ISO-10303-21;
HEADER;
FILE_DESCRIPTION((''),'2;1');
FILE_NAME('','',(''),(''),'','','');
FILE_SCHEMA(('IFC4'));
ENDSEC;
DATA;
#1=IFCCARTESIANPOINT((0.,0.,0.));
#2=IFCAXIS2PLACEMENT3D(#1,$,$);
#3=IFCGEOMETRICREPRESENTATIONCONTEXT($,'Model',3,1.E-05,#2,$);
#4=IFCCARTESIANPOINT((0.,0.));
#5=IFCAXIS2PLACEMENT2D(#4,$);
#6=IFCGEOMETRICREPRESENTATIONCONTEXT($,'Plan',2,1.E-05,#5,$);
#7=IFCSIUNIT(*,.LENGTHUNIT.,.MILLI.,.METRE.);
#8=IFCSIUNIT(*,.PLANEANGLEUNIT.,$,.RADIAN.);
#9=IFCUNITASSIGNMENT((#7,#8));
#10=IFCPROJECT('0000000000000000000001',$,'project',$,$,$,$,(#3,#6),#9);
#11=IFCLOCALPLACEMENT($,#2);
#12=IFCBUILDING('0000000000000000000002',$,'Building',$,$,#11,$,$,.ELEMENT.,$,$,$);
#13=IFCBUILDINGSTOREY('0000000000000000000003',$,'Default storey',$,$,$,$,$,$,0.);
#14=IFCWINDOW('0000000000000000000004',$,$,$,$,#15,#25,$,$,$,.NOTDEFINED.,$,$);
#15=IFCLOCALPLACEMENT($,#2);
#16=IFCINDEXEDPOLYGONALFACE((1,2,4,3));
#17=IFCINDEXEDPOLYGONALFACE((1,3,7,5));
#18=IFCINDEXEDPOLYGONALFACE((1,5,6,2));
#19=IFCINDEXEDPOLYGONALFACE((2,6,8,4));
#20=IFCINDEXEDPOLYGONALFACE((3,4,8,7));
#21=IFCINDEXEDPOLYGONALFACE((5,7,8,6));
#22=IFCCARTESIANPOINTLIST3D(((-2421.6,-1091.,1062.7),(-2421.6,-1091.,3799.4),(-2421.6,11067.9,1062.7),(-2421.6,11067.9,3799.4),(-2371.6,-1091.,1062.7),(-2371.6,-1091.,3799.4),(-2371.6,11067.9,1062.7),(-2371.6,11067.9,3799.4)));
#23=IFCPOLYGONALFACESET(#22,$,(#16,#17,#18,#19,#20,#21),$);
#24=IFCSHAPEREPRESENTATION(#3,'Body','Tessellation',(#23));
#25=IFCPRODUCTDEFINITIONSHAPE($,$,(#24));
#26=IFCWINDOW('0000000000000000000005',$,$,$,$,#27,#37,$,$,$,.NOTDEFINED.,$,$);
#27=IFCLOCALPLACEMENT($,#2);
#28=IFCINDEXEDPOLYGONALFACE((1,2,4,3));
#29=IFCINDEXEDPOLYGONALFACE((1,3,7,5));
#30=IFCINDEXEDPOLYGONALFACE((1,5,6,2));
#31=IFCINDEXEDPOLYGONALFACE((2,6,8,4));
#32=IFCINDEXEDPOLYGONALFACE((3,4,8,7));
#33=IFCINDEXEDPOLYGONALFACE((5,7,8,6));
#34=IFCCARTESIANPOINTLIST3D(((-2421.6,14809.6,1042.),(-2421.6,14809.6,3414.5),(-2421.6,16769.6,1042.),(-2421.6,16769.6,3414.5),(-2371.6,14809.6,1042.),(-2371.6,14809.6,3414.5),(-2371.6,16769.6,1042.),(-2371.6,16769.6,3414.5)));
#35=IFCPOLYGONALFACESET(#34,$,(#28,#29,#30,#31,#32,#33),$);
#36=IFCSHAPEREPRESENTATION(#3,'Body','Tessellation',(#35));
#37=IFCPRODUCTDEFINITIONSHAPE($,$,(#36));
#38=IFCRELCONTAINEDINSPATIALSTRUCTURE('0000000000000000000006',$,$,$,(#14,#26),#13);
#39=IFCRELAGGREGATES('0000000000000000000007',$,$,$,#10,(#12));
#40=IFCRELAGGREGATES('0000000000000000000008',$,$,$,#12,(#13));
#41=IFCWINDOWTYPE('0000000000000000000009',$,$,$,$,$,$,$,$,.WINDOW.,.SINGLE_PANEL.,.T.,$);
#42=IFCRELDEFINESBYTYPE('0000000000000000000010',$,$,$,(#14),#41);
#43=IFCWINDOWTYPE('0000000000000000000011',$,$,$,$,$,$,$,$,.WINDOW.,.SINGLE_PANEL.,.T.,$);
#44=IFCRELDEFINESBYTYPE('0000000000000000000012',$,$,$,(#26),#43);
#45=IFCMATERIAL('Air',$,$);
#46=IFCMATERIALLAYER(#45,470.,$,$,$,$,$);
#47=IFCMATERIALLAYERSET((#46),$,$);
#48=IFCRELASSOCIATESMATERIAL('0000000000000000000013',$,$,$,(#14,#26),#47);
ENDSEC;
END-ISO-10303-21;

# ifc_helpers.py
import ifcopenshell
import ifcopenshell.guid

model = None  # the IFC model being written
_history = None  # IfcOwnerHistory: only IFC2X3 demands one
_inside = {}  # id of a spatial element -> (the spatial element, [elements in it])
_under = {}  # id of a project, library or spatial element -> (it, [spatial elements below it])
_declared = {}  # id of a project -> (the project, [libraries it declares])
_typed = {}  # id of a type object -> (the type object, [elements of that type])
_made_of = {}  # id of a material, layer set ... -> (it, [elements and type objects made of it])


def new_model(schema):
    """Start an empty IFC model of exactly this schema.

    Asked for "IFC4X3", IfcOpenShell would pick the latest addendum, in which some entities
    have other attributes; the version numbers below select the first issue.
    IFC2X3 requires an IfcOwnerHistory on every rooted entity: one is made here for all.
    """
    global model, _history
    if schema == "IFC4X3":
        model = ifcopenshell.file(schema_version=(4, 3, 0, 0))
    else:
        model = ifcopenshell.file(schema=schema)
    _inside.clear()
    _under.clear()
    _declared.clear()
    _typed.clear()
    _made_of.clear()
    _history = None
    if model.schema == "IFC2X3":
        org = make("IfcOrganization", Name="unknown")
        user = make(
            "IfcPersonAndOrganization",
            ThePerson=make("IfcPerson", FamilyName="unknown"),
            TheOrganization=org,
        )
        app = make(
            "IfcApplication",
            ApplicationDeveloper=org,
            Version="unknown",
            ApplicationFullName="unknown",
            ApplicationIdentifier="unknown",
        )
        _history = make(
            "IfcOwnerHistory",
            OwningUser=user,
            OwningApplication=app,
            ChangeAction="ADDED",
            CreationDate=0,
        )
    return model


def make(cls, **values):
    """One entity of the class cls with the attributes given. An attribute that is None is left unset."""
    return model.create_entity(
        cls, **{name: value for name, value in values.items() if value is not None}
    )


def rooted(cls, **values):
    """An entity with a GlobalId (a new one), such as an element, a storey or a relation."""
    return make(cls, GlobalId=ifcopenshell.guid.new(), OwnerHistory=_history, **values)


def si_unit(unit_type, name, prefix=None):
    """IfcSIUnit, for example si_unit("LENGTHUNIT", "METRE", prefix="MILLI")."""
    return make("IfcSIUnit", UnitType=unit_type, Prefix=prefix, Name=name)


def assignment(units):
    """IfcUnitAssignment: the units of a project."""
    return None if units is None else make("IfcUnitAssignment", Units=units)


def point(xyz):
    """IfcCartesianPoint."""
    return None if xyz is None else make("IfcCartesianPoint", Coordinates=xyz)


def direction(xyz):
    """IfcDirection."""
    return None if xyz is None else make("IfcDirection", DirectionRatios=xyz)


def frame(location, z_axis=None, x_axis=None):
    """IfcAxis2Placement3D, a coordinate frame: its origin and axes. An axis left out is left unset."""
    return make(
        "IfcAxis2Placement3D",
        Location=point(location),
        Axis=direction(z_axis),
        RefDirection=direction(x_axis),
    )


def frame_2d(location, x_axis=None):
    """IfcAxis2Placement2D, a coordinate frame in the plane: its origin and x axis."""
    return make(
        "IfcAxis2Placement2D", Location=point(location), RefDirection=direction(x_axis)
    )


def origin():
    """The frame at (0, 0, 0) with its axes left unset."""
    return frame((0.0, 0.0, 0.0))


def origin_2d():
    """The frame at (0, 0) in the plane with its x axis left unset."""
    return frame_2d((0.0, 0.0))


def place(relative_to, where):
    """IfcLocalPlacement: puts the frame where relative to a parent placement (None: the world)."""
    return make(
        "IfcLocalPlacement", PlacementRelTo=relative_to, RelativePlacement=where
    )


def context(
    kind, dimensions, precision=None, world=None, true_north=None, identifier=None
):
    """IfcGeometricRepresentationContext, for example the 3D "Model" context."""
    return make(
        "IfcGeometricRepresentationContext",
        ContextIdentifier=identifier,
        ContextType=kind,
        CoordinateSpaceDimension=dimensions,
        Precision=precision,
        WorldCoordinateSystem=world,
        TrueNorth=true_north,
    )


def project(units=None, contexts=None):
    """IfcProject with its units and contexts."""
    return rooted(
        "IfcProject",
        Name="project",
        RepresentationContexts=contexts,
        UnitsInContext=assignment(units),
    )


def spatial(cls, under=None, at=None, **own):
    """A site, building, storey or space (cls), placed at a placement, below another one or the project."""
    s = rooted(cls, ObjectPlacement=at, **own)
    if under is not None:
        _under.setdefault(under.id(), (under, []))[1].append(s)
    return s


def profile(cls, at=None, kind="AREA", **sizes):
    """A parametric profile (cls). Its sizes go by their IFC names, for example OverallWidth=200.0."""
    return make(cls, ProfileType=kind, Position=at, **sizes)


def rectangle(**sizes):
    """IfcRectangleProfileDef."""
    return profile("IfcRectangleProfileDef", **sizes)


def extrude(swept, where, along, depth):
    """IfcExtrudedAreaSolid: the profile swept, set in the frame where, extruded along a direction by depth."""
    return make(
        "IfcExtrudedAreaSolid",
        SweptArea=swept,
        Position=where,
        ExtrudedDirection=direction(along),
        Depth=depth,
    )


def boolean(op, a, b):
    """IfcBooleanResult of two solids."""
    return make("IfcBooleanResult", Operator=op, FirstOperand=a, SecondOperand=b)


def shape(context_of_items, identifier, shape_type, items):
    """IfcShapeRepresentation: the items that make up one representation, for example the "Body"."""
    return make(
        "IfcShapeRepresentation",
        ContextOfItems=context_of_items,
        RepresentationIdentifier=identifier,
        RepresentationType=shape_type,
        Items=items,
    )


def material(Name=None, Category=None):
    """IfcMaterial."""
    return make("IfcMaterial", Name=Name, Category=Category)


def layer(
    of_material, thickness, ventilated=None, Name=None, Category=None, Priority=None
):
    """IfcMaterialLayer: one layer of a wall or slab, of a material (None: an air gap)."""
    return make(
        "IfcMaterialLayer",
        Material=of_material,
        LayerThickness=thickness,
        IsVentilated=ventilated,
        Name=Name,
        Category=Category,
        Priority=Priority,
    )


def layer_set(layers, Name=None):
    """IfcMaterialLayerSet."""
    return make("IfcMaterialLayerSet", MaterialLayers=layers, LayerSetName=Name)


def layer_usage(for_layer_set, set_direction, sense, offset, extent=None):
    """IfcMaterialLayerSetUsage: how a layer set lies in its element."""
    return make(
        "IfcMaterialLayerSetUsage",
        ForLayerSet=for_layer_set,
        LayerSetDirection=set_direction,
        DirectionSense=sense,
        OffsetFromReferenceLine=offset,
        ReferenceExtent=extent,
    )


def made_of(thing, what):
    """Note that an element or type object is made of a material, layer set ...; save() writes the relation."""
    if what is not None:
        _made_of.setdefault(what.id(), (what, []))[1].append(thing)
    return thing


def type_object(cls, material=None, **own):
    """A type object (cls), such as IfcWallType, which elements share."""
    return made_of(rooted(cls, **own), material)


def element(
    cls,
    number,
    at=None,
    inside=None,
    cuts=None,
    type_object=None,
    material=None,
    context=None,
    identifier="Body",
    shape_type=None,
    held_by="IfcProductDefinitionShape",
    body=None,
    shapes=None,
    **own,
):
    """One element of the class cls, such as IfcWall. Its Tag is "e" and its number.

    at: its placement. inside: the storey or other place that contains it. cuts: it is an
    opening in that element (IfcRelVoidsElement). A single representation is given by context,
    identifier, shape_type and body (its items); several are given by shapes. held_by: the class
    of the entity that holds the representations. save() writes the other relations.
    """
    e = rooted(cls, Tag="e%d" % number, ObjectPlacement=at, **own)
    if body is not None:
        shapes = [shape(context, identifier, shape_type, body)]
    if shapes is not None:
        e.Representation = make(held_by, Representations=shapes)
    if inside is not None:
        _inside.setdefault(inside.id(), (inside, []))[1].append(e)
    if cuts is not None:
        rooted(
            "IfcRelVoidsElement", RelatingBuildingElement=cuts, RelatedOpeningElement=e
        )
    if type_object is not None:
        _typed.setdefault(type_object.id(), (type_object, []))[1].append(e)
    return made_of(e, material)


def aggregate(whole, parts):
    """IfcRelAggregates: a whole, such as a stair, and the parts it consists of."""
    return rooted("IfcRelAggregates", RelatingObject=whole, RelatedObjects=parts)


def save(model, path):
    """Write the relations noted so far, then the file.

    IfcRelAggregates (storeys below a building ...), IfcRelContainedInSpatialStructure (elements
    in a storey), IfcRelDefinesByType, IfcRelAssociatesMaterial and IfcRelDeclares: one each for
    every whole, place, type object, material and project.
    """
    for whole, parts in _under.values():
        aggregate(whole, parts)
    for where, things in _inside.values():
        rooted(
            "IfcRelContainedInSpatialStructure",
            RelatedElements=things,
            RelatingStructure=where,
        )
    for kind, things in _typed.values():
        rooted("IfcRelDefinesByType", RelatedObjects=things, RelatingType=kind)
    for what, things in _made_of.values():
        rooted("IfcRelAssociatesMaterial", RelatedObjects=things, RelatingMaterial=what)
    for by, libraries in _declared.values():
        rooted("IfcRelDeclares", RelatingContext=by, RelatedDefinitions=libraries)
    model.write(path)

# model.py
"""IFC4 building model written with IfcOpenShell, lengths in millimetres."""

from ifc_helpers import new_model, si_unit, frame, origin, origin_2d, place, context, project, spatial, rectangle, extrude, boolean, material, layer, layer_set, layer_usage, type_object, element, save


model = new_model("IFC4")

# Units and contexts
model_context = context("Model", 3, precision=1e-05, world=origin())
plan_context = context("Plan", 2, precision=1e-05, world=origin_2d())
ifc_project = project(units=[si_unit("LENGTHUNIT", "METRE", prefix="MILLI"), si_unit("PLANEANGLEUNIT", "RADIAN")], contexts=[model_context, plan_context])

# Building, storey
placement = place(None, origin())
building = spatial("IfcBuilding", under=ifc_project, at=placement, Name="Building", CompositionType="ELEMENT")
storey = spatial("IfcBuildingStorey", under=building, Name="Default storey", Elevation=0.0)

# Windows
ifc_material_1 = material(Name="Air")
ifc_layer = layer(ifc_material_1, 470.0)
ifc_layer_set = layer_set([ifc_layer])
ifc_layer_usage = layer_usage(ifc_layer_set, "AXIS3", "POSITIVE", 0.0)
window_type_1 = type_object("IfcWindowType", ParameterTakesPrecedence=True, PartitioningType="SINGLE_PANEL", PredefinedType="WINDOW")
element("IfcWindow", 1, at=placement, inside=storey, type_object=window_type_1, material=ifc_layer_usage, PredefinedType="NOTDEFINED", context=model_context, shape_type="CSG", body=[
    boolean("INTERSECTION", extrude(rectangle(XDim=12158.9, YDim=50.0, at=origin_2d()), frame((-2396.6, 4988.4, 1062.7), z_axis=(0.0, 0.0, 1000.0), x_axis=(0.0, 12158.909678, 0.0)), (0.0, 0.0, 1.0), 2736.7), extrude(rectangle(XDim=12158.9, YDim=50.0, at=origin_2d()), frame((-2396.6, 4988.4, 1062.7), z_axis=(0.0, 0.0, 1000.0), x_axis=(0.0, 12158.909678, 0.0)), (0.0, 0.0, 1.0), 2736.7)),
])
window_type_2 = type_object("IfcWindowType", ParameterTakesPrecedence=True, PartitioningType="SINGLE_PANEL", PredefinedType="WINDOW")
element("IfcWindow", 2, at=placement, inside=storey, type_object=window_type_2, material=ifc_layer_usage, PredefinedType="NOTDEFINED", context=model_context, shape_type="CSG", body=[
    boolean("INTERSECTION", extrude(rectangle(XDim=1960.0, YDim=50.0, at=origin_2d()), frame((-2396.6, 15789.6, 1042.0), z_axis=(0.0, 0.0, 1000.0), x_axis=(0.0, 1960.000038, 0.0)), (0.0, 0.0, 1.0), 2372.5), extrude(rectangle(XDim=1960.0, YDim=50.0, at=origin_2d()), frame((-2396.6, 15789.6, 1042.0), z_axis=(0.0, 0.0, 1000.0), x_axis=(0.0, 1960.000038, 0.0)), (0.0, 0.0, 1.0), 2372.5)),
])

save(model, "model.ifc")
